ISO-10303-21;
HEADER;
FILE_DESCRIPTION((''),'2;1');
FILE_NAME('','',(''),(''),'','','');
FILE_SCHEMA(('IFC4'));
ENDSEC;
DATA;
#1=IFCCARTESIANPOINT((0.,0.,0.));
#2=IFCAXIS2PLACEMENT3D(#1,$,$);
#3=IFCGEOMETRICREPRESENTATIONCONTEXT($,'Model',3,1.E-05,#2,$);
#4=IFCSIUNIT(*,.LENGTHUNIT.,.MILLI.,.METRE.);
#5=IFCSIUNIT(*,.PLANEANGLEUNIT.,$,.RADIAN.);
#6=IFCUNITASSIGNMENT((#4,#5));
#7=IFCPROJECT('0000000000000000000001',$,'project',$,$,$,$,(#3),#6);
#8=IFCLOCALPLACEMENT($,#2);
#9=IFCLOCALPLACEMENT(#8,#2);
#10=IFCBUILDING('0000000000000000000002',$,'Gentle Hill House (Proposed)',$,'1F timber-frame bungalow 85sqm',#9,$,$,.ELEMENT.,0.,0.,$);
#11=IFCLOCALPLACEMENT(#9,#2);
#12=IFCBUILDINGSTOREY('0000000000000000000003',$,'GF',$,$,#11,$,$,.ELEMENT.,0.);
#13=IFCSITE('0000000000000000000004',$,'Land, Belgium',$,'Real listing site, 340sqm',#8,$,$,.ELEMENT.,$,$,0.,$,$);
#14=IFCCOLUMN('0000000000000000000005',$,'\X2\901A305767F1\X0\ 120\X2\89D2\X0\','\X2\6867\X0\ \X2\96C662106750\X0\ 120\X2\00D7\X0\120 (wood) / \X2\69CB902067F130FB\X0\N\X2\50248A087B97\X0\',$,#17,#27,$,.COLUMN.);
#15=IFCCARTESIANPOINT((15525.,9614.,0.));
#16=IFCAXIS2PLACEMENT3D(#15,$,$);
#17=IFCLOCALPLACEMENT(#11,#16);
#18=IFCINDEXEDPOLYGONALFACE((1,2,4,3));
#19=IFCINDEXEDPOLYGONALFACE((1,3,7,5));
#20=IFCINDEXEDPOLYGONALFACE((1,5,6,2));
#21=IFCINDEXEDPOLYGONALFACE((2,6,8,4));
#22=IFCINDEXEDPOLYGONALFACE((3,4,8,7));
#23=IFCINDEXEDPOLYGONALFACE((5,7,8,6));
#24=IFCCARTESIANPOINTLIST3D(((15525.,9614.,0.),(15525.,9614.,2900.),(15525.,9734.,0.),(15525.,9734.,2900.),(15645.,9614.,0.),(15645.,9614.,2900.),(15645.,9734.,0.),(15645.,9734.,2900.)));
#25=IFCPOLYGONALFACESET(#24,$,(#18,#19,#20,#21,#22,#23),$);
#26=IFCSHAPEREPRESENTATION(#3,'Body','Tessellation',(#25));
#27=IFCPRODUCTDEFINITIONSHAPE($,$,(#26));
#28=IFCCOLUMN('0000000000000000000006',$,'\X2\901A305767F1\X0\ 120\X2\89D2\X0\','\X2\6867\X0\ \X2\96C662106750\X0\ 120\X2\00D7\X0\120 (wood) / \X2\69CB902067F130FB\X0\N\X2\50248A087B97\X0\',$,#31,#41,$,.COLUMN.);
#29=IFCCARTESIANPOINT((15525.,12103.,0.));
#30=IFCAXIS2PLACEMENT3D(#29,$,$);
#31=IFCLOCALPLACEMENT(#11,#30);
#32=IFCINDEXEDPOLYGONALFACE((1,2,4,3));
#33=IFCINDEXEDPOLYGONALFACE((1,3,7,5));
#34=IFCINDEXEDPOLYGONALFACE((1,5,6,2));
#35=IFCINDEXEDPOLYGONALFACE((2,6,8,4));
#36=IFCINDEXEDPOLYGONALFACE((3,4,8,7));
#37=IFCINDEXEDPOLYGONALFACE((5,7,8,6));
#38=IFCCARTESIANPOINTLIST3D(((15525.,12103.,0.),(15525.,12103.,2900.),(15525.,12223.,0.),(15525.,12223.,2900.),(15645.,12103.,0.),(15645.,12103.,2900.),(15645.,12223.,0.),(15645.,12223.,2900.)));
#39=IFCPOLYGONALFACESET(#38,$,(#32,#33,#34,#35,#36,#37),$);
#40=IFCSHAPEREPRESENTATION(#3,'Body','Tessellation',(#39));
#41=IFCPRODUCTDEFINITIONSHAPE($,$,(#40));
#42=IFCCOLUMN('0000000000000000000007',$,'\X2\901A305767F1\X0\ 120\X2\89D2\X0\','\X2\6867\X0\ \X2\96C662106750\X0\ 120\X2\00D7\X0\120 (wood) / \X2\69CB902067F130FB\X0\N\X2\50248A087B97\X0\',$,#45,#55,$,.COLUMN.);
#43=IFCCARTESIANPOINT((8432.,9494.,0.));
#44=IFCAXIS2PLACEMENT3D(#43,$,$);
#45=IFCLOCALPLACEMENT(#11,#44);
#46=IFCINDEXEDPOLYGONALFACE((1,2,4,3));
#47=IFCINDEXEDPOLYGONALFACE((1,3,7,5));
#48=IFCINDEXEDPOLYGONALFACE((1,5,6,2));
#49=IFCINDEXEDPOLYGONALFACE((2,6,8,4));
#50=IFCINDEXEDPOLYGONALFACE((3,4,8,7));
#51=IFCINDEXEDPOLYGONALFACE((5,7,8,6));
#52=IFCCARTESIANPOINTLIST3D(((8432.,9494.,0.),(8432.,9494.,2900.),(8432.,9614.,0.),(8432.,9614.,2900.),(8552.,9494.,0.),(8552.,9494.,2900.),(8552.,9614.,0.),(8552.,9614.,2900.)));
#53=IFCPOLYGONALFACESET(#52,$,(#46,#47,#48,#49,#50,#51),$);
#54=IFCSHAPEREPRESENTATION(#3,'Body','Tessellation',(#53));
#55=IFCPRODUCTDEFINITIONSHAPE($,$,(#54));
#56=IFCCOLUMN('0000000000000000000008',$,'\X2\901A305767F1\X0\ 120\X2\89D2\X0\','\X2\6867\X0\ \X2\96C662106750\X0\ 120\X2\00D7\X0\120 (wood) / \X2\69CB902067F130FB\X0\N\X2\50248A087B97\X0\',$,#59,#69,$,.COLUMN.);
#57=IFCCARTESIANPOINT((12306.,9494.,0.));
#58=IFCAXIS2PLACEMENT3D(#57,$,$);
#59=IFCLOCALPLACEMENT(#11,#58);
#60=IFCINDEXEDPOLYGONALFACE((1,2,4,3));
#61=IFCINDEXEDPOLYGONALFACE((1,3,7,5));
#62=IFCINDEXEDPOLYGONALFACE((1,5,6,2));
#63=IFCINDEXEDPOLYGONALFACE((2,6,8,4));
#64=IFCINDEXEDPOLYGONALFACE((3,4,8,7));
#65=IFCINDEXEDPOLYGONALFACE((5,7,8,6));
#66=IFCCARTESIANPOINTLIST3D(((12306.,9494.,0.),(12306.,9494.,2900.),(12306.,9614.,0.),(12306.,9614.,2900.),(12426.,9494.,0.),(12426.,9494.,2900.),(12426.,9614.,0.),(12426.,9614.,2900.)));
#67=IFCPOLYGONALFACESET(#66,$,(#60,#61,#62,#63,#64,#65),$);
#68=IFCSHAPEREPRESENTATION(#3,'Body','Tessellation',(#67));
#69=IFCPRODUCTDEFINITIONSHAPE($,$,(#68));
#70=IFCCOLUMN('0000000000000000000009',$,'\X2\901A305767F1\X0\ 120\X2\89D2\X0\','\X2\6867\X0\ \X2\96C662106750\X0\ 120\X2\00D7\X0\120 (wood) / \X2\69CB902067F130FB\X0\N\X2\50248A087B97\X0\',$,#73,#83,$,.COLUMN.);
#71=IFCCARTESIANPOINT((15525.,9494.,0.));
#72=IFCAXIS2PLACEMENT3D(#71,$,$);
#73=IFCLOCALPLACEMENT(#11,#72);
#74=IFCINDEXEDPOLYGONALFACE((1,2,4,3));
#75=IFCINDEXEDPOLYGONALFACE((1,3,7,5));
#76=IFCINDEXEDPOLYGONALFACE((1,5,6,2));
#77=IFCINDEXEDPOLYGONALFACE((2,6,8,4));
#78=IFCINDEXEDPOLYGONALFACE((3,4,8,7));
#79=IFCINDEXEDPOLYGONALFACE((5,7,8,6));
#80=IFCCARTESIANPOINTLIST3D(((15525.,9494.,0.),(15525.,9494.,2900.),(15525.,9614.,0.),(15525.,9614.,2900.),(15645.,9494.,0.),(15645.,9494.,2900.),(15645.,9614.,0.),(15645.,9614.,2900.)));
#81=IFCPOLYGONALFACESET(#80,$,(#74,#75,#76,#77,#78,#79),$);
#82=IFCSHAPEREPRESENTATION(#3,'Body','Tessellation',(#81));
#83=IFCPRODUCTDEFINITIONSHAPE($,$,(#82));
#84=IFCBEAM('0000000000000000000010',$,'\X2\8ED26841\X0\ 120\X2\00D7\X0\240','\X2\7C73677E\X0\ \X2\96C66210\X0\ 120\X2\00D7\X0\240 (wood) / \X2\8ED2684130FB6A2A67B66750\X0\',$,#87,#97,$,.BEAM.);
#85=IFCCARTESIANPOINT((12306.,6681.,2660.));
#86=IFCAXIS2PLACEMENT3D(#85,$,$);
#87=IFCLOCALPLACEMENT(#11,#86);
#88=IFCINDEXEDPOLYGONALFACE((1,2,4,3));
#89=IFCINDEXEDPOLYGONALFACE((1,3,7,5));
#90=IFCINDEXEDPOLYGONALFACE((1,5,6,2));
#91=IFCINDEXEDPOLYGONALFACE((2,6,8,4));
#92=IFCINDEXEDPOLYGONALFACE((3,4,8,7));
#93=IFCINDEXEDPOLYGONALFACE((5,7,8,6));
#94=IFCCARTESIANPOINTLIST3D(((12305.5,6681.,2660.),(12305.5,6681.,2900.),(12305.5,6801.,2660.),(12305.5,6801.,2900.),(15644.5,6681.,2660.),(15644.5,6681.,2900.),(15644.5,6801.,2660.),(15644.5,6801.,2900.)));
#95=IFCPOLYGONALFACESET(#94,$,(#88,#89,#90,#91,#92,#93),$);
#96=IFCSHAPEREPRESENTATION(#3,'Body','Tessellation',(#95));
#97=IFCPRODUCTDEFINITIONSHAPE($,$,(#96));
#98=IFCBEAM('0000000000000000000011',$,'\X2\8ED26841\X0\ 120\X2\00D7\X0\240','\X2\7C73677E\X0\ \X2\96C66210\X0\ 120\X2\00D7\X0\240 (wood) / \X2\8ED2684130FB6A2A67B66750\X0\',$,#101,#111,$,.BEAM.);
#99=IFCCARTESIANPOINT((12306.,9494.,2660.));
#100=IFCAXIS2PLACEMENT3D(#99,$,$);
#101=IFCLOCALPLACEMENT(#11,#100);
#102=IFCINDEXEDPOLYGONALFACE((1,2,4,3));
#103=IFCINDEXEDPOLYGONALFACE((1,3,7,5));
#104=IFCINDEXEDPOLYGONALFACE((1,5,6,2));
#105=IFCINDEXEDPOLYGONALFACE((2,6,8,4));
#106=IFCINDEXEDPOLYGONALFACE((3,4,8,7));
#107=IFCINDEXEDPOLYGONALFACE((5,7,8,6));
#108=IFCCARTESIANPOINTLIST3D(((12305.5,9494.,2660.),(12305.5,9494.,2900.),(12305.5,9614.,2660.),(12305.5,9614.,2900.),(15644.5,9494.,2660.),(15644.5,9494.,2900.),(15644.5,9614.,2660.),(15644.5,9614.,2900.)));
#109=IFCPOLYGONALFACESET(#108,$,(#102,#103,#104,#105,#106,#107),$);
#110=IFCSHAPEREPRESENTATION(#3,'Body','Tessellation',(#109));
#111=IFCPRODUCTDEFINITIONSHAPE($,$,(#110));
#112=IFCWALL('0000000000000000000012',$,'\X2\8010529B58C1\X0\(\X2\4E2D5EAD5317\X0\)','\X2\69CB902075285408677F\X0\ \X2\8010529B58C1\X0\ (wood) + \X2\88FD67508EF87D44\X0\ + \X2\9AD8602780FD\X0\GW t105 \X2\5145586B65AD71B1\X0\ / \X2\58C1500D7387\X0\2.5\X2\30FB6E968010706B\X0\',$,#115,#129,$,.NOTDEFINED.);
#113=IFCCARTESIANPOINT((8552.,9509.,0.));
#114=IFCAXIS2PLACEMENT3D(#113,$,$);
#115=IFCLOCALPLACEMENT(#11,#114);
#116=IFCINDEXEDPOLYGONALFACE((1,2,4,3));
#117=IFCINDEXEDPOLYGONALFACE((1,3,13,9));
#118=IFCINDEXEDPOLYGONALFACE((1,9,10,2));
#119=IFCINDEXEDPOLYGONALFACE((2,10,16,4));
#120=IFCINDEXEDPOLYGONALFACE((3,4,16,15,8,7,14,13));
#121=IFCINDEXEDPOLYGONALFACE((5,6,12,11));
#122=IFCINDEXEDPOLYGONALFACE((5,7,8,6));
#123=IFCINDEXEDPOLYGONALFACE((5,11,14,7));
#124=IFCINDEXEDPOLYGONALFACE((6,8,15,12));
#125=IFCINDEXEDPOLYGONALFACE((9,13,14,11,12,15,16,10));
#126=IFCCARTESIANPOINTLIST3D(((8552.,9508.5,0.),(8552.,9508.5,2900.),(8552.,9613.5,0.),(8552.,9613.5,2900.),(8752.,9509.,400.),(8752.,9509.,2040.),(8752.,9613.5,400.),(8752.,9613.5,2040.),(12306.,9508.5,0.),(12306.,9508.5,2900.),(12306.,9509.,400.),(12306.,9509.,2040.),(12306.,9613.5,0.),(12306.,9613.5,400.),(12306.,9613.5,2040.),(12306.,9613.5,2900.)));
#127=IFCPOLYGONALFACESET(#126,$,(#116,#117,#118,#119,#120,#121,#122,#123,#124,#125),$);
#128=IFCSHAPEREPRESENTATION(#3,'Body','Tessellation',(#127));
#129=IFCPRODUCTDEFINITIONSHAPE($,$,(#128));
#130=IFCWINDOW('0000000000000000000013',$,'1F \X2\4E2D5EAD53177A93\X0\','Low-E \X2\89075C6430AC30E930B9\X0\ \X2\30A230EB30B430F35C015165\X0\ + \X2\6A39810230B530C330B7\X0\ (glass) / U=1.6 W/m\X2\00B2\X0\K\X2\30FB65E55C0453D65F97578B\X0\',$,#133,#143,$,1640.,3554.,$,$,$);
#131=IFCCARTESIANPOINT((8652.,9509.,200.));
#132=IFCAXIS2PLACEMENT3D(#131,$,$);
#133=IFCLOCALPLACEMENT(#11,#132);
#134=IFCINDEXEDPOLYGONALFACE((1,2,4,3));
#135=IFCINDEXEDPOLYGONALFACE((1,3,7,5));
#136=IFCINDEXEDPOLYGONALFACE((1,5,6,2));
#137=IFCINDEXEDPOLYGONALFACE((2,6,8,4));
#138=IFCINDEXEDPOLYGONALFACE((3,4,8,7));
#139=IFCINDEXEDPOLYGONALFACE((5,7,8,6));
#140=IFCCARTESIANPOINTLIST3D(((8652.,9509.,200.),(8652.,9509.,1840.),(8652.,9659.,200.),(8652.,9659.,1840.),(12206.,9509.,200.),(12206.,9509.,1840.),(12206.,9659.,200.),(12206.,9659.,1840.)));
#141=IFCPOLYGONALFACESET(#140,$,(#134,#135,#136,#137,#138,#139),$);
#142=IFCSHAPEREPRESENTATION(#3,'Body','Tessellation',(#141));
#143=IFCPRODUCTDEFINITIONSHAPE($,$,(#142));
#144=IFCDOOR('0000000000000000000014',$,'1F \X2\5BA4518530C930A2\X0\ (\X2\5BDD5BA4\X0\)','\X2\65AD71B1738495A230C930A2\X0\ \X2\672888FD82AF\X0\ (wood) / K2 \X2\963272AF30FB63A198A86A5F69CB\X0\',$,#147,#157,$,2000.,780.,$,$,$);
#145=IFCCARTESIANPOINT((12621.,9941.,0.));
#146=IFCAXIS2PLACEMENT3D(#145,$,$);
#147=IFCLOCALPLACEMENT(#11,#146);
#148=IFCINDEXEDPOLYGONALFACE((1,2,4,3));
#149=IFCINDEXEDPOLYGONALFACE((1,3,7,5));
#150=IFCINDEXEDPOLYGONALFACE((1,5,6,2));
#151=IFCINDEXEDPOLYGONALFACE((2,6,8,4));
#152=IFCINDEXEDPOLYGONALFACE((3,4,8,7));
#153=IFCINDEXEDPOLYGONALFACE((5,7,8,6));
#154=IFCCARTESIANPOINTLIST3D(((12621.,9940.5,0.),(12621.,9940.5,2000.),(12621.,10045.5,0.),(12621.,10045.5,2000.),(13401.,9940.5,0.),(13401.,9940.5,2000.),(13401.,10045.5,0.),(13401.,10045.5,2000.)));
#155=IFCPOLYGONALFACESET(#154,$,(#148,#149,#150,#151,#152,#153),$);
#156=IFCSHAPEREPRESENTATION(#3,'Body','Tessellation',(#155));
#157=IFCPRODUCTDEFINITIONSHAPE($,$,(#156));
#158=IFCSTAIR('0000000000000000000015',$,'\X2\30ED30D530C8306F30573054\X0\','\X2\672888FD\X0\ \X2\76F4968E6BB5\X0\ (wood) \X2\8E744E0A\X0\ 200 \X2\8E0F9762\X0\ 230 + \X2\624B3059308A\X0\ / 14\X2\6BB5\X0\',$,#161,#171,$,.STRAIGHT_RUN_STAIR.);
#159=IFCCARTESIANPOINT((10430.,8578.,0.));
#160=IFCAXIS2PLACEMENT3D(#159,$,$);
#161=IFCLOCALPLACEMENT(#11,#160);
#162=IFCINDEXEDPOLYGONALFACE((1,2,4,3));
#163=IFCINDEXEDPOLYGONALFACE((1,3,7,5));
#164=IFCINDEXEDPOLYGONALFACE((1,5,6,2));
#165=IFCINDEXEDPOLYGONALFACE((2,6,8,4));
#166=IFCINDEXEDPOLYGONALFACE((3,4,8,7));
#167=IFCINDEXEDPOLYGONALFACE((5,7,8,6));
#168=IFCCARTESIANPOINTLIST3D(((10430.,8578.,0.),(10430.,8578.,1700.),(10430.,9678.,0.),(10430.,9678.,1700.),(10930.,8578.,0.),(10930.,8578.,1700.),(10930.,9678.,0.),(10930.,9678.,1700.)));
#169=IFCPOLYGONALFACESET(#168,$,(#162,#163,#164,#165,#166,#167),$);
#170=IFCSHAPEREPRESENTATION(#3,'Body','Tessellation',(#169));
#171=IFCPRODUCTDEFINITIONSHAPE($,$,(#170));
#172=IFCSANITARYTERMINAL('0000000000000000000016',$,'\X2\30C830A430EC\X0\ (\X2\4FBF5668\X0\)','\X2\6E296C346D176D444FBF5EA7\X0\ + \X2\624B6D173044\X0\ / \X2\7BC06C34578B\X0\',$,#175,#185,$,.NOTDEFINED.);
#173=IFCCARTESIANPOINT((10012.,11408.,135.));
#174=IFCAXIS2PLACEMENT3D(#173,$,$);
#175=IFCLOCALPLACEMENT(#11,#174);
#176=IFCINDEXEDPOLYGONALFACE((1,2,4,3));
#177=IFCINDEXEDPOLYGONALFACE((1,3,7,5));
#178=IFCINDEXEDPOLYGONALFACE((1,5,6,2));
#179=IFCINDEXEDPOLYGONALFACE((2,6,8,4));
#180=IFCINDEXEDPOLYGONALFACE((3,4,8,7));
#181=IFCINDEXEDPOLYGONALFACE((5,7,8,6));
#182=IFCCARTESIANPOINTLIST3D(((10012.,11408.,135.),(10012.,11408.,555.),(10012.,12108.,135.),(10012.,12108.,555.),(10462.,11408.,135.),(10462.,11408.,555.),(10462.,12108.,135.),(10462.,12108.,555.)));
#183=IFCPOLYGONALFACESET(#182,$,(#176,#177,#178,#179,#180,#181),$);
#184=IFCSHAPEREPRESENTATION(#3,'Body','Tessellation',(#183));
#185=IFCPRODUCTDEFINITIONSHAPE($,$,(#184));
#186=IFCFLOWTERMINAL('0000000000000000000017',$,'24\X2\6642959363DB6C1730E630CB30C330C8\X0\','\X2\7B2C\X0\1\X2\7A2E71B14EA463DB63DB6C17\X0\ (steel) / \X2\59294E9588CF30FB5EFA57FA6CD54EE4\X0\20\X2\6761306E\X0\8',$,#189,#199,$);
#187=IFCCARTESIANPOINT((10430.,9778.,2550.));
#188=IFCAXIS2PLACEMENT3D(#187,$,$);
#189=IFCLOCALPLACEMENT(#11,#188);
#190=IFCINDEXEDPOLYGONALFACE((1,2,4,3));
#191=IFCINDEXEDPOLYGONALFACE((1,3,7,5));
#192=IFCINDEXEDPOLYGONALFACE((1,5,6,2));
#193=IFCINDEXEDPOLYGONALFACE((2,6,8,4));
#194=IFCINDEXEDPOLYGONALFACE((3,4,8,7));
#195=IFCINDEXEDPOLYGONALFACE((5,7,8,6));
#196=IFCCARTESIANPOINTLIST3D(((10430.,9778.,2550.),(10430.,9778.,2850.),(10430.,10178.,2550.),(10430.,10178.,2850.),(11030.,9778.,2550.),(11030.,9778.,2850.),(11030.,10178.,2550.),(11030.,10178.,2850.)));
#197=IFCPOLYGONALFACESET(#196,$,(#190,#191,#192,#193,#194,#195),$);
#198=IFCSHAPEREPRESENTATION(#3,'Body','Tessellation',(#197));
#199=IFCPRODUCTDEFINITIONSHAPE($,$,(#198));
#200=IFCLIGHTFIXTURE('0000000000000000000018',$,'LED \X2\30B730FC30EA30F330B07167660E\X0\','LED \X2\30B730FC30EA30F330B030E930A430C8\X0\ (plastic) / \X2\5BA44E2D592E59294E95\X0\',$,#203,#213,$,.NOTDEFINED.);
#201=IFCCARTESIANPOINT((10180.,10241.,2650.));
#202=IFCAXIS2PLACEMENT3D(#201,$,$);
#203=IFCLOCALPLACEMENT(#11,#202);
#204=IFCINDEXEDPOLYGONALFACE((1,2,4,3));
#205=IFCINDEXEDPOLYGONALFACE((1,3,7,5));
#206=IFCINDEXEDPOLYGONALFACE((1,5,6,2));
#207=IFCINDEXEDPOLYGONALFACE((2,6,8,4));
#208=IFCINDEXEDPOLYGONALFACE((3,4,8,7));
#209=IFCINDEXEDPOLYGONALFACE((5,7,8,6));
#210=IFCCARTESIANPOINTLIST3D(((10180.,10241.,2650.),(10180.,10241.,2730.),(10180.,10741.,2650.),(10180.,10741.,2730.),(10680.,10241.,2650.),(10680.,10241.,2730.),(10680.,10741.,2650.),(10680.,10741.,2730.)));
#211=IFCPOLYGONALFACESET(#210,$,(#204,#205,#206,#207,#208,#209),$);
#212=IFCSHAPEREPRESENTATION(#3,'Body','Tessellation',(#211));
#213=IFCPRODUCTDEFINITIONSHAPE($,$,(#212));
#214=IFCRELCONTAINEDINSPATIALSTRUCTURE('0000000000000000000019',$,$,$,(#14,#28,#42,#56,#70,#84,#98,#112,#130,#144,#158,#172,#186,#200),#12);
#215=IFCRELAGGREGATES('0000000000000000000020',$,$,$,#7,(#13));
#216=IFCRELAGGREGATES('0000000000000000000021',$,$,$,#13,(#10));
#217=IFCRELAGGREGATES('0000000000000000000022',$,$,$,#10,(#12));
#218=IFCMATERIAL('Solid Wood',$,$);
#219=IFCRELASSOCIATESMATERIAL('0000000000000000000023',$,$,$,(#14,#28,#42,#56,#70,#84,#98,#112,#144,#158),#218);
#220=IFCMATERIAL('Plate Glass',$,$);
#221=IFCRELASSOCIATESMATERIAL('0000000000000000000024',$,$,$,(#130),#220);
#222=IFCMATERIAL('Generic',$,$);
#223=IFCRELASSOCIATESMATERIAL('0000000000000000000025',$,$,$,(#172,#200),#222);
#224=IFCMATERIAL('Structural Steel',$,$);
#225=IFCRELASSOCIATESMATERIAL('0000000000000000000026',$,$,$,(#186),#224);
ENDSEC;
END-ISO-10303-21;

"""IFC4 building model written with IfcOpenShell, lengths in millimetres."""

from ifc_helpers import new_model, si_unit, frame, frame_2d, origin, place, context, project, spatial, rectangle, extrude, material, element, fill, save


model = new_model("IFC4")

# Units and contexts
model_context = context("Model", 3, precision=1e-05, world=origin())
ifc_project = project(units=[si_unit("LENGTHUNIT", "METRE", prefix="MILLI"), si_unit("PLANEANGLEUNIT", "RADIAN")], contexts=[model_context])

# Site, building, storey
site_placement = place(None, origin())
site = spatial("IfcSite", under=ifc_project, at=site_placement, Name="Land, Belgium", ObjectType="Real listing site, 340sqm", CompositionType="ELEMENT", RefElevation=0.0)
building_placement = place(site_placement, origin())
building = spatial("IfcBuilding", under=site, at=building_placement, Name="Gentle Hill House (Proposed)", ObjectType="1F timber-frame bungalow 85sqm", CompositionType="ELEMENT", ElevationOfRefHeight=0.0, ElevationOfTerrain=0.0)
storey_placement = place(building_placement, origin())
storey = spatial("IfcBuildingStorey", under=building, at=storey_placement, Name="GF", CompositionType="ELEMENT", Elevation=0.0)

# Columns
ifc_material_1 = material(Name="Solid Wood")
column_1_placement = place(storey_placement, frame((15525.0, 9614.0, 0.0)))
element("IfcColumn", 1, at=column_1_placement, inside=storey, material=ifc_material_1, Name="通し柱 120角", Description="桧 集成材 120×120 (wood) / 構造柱・N値計算", PredefinedType="COLUMN", context=model_context, shape_type="SweptSolid", body=[
    extrude(rectangle(XDim=120.0, YDim=120.0, at=frame_2d((60.0, 60.0))), frame((15525.0, 9614.0, 0.0)), (0.0, 0.0, 1.0), 2900.0),
])
column_2_placement = place(storey_placement, frame((15525.0, 12103.0, 0.0)))
element("IfcColumn", 2, at=column_2_placement, inside=storey, material=ifc_material_1, Name="通し柱 120角", Description="桧 集成材 120×120 (wood) / 構造柱・N値計算", PredefinedType="COLUMN", context=model_context, shape_type="SweptSolid", body=[
    extrude(rectangle(XDim=120.0, YDim=120.0, at=frame_2d((60.0, 60.0))), frame((15525.0, 12103.0, 0.0)), (0.0, 0.0, 1.0), 2900.0),
])
column_3_placement = place(storey_placement, frame((8432.0, 9494.0, 0.0)))
element("IfcColumn", 3, at=column_3_placement, inside=storey, material=ifc_material_1, Name="通し柱 120角", Description="桧 集成材 120×120 (wood) / 構造柱・N値計算", PredefinedType="COLUMN", context=model_context, shape_type="SweptSolid", body=[
    extrude(rectangle(XDim=120.0, YDim=120.0, at=frame_2d((60.0, 60.0))), frame((8432.0, 9494.0, 0.0)), (0.0, 0.0, 1.0), 2900.0),
])
column_4_placement = place(storey_placement, frame((12306.0, 9494.0, 0.0)))
element("IfcColumn", 4, at=column_4_placement, inside=storey, material=ifc_material_1, Name="通し柱 120角", Description="桧 集成材 120×120 (wood) / 構造柱・N値計算", PredefinedType="COLUMN", context=model_context, shape_type="SweptSolid", body=[
    extrude(rectangle(XDim=120.0, YDim=120.0, at=frame_2d((60.0, 60.0))), frame((12306.0, 9494.0, 0.0)), (0.0, 0.0, 1.0), 2900.0),
])
column_5_placement = place(storey_placement, frame((15525.0, 9494.0, 0.0)))
element("IfcColumn", 5, at=column_5_placement, inside=storey, material=ifc_material_1, Name="通し柱 120角", Description="桧 集成材 120×120 (wood) / 構造柱・N値計算", PredefinedType="COLUMN", context=model_context, shape_type="SweptSolid", body=[
    extrude(rectangle(XDim=120.0, YDim=120.0, at=frame_2d((60.0, 60.0))), frame((15525.0, 9494.0, 0.0)), (0.0, 0.0, 1.0), 2900.0),
])

# Beams
beam_1_placement = place(storey_placement, frame((12306.0, 6681.0, 2660.0)))
element("IfcBeam", 6, at=beam_1_placement, inside=storey, material=ifc_material_1, Name="軒桁 120×240", Description="米松 集成 120×240 (wood) / 軒桁・横架材", PredefinedType="BEAM", context=model_context, shape_type="SweptSolid", body=[
    extrude(rectangle(XDim=3339.0, YDim=120.0, at=frame_2d((1669.0, 60.0))), frame((12306.0, 6681.0, 2660.0)), (0.0, 0.0, 1.0), 240.0),
])
beam_2_placement = place(storey_placement, frame((12306.0, 9494.0, 2660.0)))
element("IfcBeam", 7, at=beam_2_placement, inside=storey, material=ifc_material_1, Name="軒桁 120×240", Description="米松 集成 120×240 (wood) / 軒桁・横架材", PredefinedType="BEAM", context=model_context, shape_type="SweptSolid", body=[
    extrude(rectangle(XDim=3339.0, YDim=120.0, at=frame_2d((1669.0, 60.0))), frame((12306.0, 9494.0, 2660.0)), (0.0, 0.0, 1.0), 240.0),
])

# Wall, opening, window
wall_1_placement = place(storey_placement, frame((8552.0, 9509.0, 0.0)))
wall_1 = element("IfcWall", 8, at=wall_1_placement, inside=storey, material=ifc_material_1, Name="耐力壁(中庭北)", Description="構造用合板 耐力壁 (wood) + 製材軸組 + 高性能GW t105 充填断熱 / 壁倍率2.5・準耐火", PredefinedType="NOTDEFINED", context=model_context, shape_type="SweptSolid", body=[
    extrude(rectangle(XDim=3754.0, YDim=105.0, at=frame_2d((1877.0, 52.0))), frame((8552.0, 9509.0, 0.0)), (0.0, 0.0, 1.0), 2900.0),
])
opening_placement = place(storey_placement, frame((8652.0, 9509.0, 200.0)))
opening = element("IfcOpeningElement", 9, at=opening_placement, cuts=wall_1, PredefinedType="NOTDEFINED", context=model_context, shape_type="SweptSolid", body=[
    extrude(rectangle(XDim=3554.0, YDim=150.0, at=frame_2d((1777.0, 75.0))), frame((8652.0, 9509.0, 200.0)), (0.0, 0.0, 1.0), 1640.0),
])
ifc_material_2 = material(Name="Plate Glass")
window_placement = place(storey_placement, frame((8652.0, 9509.0, 200.0)))
window = element("IfcWindow", 10, at=window_placement, inside=storey, material=ifc_material_2, Name="1F 中庭北窓", Description="Low-E 複層ガラス アルゴン封入 + 樹脂サッシ (glass) / U=1.6 W/m²K・日射取得型", OverallHeight=1640.0, OverallWidth=3554.0, context=model_context, shape_type="SweptSolid", body=[
    extrude(rectangle(XDim=3554.0, YDim=150.0, at=frame_2d((1777.0, 75.0))), frame((8652.0, 9509.0, 200.0)), (0.0, 0.0, 1.0), 1640.0),
])
fill(opening, window)

# Door
door_placement = place(storey_placement, frame((12621.0, 9941.0, 0.0)))
element("IfcDoor", 11, at=door_placement, inside=storey, material=ifc_material_1, Name="1F 室内ドア (寝室)", Description="断熱玄関ドア 木製芯 (wood) / K2 防犯・採風機構", OverallHeight=2000.0, OverallWidth=780.0, context=model_context, shape_type="SweptSolid", body=[
    extrude(rectangle(XDim=780.0, YDim=105.0, at=frame_2d((390.0, 52.0))), frame((12621.0, 9941.0, 0.0)), (0.0, 0.0, 1.0), 2000.0),
])

# Stair
stair_placement = place(storey_placement, frame((10430.0, 8578.0, 0.0)))
element("IfcStair", 12, at=stair_placement, inside=storey, material=ifc_material_1, Name="ロフトはしご", Description="木製 直階段 (wood) 蹴上 200 踏面 230 + 手すり / 14段", PredefinedType="STRAIGHT_RUN_STAIR", context=model_context, shape_type="SweptSolid", body=[
    extrude(rectangle(XDim=500.0, YDim=1100.0, at=frame_2d((250.0, 550.0))), frame((10430.0, 8578.0, 0.0)), (0.0, 0.0, 1.0), 1700.0),
])

# Shared definitions
ifc_material_3 = material(Name="Generic")

# Sanitary terminal
sanitary_terminal_placement = place(storey_placement, frame((10012.0, 11408.0, 135.0)))
element("IfcSanitaryTerminal", 13, at=sanitary_terminal_placement, inside=storey, material=ifc_material_3, Name="トイレ (便器)", Description="温水洗浄便座 + 手洗い / 節水型", PredefinedType="NOTDEFINED", context=model_context, shape_type="SweptSolid", body=[
    extrude(rectangle(XDim=450.0, YDim=700.0, at=frame_2d((225.0, 350.0))), frame((10012.0, 11408.0, 135.0)), (0.0, 0.0, 1.0), 420.0),
])

# Flow terminal
ifc_material_4 = material(Name="Structural Steel")
flow_terminal_placement = place(storey_placement, frame((10430.0, 9778.0, 2550.0)))
element("IfcFlowTerminal", 14, at=flow_terminal_placement, inside=storey, material=ifc_material_4, Name="24時間換気ユニット", Description="第1種熱交換換気 (steel) / 天井裏・建基法令20条の8", context=model_context, shape_type="SweptSolid", body=[
    extrude(rectangle(XDim=600.0, YDim=400.0, at=frame_2d((300.0, 200.0))), frame((10430.0, 9778.0, 2550.0)), (0.0, 0.0, 1.0), 300.0),
])

# Light fixture
light_fixture_1_placement = place(storey_placement, frame((10180.0, 10241.0, 2650.0)))
element("IfcLightFixture", 15, at=light_fixture_1_placement, inside=storey, material=ifc_material_3, Name="LED シーリング照明", Description="LED シーリングライト (plastic) / 室中央天井", PredefinedType="NOTDEFINED", context=model_context, shape_type="SweptSolid", body=[
    extrude(rectangle(XDim=500.0, YDim=500.0, at=frame_2d((250.0, 250.0))), frame((10180.0, 10241.0, 2650.0)), (0.0, 0.0, 1.0), 80.0),
])

save(model, "model.ifc")
